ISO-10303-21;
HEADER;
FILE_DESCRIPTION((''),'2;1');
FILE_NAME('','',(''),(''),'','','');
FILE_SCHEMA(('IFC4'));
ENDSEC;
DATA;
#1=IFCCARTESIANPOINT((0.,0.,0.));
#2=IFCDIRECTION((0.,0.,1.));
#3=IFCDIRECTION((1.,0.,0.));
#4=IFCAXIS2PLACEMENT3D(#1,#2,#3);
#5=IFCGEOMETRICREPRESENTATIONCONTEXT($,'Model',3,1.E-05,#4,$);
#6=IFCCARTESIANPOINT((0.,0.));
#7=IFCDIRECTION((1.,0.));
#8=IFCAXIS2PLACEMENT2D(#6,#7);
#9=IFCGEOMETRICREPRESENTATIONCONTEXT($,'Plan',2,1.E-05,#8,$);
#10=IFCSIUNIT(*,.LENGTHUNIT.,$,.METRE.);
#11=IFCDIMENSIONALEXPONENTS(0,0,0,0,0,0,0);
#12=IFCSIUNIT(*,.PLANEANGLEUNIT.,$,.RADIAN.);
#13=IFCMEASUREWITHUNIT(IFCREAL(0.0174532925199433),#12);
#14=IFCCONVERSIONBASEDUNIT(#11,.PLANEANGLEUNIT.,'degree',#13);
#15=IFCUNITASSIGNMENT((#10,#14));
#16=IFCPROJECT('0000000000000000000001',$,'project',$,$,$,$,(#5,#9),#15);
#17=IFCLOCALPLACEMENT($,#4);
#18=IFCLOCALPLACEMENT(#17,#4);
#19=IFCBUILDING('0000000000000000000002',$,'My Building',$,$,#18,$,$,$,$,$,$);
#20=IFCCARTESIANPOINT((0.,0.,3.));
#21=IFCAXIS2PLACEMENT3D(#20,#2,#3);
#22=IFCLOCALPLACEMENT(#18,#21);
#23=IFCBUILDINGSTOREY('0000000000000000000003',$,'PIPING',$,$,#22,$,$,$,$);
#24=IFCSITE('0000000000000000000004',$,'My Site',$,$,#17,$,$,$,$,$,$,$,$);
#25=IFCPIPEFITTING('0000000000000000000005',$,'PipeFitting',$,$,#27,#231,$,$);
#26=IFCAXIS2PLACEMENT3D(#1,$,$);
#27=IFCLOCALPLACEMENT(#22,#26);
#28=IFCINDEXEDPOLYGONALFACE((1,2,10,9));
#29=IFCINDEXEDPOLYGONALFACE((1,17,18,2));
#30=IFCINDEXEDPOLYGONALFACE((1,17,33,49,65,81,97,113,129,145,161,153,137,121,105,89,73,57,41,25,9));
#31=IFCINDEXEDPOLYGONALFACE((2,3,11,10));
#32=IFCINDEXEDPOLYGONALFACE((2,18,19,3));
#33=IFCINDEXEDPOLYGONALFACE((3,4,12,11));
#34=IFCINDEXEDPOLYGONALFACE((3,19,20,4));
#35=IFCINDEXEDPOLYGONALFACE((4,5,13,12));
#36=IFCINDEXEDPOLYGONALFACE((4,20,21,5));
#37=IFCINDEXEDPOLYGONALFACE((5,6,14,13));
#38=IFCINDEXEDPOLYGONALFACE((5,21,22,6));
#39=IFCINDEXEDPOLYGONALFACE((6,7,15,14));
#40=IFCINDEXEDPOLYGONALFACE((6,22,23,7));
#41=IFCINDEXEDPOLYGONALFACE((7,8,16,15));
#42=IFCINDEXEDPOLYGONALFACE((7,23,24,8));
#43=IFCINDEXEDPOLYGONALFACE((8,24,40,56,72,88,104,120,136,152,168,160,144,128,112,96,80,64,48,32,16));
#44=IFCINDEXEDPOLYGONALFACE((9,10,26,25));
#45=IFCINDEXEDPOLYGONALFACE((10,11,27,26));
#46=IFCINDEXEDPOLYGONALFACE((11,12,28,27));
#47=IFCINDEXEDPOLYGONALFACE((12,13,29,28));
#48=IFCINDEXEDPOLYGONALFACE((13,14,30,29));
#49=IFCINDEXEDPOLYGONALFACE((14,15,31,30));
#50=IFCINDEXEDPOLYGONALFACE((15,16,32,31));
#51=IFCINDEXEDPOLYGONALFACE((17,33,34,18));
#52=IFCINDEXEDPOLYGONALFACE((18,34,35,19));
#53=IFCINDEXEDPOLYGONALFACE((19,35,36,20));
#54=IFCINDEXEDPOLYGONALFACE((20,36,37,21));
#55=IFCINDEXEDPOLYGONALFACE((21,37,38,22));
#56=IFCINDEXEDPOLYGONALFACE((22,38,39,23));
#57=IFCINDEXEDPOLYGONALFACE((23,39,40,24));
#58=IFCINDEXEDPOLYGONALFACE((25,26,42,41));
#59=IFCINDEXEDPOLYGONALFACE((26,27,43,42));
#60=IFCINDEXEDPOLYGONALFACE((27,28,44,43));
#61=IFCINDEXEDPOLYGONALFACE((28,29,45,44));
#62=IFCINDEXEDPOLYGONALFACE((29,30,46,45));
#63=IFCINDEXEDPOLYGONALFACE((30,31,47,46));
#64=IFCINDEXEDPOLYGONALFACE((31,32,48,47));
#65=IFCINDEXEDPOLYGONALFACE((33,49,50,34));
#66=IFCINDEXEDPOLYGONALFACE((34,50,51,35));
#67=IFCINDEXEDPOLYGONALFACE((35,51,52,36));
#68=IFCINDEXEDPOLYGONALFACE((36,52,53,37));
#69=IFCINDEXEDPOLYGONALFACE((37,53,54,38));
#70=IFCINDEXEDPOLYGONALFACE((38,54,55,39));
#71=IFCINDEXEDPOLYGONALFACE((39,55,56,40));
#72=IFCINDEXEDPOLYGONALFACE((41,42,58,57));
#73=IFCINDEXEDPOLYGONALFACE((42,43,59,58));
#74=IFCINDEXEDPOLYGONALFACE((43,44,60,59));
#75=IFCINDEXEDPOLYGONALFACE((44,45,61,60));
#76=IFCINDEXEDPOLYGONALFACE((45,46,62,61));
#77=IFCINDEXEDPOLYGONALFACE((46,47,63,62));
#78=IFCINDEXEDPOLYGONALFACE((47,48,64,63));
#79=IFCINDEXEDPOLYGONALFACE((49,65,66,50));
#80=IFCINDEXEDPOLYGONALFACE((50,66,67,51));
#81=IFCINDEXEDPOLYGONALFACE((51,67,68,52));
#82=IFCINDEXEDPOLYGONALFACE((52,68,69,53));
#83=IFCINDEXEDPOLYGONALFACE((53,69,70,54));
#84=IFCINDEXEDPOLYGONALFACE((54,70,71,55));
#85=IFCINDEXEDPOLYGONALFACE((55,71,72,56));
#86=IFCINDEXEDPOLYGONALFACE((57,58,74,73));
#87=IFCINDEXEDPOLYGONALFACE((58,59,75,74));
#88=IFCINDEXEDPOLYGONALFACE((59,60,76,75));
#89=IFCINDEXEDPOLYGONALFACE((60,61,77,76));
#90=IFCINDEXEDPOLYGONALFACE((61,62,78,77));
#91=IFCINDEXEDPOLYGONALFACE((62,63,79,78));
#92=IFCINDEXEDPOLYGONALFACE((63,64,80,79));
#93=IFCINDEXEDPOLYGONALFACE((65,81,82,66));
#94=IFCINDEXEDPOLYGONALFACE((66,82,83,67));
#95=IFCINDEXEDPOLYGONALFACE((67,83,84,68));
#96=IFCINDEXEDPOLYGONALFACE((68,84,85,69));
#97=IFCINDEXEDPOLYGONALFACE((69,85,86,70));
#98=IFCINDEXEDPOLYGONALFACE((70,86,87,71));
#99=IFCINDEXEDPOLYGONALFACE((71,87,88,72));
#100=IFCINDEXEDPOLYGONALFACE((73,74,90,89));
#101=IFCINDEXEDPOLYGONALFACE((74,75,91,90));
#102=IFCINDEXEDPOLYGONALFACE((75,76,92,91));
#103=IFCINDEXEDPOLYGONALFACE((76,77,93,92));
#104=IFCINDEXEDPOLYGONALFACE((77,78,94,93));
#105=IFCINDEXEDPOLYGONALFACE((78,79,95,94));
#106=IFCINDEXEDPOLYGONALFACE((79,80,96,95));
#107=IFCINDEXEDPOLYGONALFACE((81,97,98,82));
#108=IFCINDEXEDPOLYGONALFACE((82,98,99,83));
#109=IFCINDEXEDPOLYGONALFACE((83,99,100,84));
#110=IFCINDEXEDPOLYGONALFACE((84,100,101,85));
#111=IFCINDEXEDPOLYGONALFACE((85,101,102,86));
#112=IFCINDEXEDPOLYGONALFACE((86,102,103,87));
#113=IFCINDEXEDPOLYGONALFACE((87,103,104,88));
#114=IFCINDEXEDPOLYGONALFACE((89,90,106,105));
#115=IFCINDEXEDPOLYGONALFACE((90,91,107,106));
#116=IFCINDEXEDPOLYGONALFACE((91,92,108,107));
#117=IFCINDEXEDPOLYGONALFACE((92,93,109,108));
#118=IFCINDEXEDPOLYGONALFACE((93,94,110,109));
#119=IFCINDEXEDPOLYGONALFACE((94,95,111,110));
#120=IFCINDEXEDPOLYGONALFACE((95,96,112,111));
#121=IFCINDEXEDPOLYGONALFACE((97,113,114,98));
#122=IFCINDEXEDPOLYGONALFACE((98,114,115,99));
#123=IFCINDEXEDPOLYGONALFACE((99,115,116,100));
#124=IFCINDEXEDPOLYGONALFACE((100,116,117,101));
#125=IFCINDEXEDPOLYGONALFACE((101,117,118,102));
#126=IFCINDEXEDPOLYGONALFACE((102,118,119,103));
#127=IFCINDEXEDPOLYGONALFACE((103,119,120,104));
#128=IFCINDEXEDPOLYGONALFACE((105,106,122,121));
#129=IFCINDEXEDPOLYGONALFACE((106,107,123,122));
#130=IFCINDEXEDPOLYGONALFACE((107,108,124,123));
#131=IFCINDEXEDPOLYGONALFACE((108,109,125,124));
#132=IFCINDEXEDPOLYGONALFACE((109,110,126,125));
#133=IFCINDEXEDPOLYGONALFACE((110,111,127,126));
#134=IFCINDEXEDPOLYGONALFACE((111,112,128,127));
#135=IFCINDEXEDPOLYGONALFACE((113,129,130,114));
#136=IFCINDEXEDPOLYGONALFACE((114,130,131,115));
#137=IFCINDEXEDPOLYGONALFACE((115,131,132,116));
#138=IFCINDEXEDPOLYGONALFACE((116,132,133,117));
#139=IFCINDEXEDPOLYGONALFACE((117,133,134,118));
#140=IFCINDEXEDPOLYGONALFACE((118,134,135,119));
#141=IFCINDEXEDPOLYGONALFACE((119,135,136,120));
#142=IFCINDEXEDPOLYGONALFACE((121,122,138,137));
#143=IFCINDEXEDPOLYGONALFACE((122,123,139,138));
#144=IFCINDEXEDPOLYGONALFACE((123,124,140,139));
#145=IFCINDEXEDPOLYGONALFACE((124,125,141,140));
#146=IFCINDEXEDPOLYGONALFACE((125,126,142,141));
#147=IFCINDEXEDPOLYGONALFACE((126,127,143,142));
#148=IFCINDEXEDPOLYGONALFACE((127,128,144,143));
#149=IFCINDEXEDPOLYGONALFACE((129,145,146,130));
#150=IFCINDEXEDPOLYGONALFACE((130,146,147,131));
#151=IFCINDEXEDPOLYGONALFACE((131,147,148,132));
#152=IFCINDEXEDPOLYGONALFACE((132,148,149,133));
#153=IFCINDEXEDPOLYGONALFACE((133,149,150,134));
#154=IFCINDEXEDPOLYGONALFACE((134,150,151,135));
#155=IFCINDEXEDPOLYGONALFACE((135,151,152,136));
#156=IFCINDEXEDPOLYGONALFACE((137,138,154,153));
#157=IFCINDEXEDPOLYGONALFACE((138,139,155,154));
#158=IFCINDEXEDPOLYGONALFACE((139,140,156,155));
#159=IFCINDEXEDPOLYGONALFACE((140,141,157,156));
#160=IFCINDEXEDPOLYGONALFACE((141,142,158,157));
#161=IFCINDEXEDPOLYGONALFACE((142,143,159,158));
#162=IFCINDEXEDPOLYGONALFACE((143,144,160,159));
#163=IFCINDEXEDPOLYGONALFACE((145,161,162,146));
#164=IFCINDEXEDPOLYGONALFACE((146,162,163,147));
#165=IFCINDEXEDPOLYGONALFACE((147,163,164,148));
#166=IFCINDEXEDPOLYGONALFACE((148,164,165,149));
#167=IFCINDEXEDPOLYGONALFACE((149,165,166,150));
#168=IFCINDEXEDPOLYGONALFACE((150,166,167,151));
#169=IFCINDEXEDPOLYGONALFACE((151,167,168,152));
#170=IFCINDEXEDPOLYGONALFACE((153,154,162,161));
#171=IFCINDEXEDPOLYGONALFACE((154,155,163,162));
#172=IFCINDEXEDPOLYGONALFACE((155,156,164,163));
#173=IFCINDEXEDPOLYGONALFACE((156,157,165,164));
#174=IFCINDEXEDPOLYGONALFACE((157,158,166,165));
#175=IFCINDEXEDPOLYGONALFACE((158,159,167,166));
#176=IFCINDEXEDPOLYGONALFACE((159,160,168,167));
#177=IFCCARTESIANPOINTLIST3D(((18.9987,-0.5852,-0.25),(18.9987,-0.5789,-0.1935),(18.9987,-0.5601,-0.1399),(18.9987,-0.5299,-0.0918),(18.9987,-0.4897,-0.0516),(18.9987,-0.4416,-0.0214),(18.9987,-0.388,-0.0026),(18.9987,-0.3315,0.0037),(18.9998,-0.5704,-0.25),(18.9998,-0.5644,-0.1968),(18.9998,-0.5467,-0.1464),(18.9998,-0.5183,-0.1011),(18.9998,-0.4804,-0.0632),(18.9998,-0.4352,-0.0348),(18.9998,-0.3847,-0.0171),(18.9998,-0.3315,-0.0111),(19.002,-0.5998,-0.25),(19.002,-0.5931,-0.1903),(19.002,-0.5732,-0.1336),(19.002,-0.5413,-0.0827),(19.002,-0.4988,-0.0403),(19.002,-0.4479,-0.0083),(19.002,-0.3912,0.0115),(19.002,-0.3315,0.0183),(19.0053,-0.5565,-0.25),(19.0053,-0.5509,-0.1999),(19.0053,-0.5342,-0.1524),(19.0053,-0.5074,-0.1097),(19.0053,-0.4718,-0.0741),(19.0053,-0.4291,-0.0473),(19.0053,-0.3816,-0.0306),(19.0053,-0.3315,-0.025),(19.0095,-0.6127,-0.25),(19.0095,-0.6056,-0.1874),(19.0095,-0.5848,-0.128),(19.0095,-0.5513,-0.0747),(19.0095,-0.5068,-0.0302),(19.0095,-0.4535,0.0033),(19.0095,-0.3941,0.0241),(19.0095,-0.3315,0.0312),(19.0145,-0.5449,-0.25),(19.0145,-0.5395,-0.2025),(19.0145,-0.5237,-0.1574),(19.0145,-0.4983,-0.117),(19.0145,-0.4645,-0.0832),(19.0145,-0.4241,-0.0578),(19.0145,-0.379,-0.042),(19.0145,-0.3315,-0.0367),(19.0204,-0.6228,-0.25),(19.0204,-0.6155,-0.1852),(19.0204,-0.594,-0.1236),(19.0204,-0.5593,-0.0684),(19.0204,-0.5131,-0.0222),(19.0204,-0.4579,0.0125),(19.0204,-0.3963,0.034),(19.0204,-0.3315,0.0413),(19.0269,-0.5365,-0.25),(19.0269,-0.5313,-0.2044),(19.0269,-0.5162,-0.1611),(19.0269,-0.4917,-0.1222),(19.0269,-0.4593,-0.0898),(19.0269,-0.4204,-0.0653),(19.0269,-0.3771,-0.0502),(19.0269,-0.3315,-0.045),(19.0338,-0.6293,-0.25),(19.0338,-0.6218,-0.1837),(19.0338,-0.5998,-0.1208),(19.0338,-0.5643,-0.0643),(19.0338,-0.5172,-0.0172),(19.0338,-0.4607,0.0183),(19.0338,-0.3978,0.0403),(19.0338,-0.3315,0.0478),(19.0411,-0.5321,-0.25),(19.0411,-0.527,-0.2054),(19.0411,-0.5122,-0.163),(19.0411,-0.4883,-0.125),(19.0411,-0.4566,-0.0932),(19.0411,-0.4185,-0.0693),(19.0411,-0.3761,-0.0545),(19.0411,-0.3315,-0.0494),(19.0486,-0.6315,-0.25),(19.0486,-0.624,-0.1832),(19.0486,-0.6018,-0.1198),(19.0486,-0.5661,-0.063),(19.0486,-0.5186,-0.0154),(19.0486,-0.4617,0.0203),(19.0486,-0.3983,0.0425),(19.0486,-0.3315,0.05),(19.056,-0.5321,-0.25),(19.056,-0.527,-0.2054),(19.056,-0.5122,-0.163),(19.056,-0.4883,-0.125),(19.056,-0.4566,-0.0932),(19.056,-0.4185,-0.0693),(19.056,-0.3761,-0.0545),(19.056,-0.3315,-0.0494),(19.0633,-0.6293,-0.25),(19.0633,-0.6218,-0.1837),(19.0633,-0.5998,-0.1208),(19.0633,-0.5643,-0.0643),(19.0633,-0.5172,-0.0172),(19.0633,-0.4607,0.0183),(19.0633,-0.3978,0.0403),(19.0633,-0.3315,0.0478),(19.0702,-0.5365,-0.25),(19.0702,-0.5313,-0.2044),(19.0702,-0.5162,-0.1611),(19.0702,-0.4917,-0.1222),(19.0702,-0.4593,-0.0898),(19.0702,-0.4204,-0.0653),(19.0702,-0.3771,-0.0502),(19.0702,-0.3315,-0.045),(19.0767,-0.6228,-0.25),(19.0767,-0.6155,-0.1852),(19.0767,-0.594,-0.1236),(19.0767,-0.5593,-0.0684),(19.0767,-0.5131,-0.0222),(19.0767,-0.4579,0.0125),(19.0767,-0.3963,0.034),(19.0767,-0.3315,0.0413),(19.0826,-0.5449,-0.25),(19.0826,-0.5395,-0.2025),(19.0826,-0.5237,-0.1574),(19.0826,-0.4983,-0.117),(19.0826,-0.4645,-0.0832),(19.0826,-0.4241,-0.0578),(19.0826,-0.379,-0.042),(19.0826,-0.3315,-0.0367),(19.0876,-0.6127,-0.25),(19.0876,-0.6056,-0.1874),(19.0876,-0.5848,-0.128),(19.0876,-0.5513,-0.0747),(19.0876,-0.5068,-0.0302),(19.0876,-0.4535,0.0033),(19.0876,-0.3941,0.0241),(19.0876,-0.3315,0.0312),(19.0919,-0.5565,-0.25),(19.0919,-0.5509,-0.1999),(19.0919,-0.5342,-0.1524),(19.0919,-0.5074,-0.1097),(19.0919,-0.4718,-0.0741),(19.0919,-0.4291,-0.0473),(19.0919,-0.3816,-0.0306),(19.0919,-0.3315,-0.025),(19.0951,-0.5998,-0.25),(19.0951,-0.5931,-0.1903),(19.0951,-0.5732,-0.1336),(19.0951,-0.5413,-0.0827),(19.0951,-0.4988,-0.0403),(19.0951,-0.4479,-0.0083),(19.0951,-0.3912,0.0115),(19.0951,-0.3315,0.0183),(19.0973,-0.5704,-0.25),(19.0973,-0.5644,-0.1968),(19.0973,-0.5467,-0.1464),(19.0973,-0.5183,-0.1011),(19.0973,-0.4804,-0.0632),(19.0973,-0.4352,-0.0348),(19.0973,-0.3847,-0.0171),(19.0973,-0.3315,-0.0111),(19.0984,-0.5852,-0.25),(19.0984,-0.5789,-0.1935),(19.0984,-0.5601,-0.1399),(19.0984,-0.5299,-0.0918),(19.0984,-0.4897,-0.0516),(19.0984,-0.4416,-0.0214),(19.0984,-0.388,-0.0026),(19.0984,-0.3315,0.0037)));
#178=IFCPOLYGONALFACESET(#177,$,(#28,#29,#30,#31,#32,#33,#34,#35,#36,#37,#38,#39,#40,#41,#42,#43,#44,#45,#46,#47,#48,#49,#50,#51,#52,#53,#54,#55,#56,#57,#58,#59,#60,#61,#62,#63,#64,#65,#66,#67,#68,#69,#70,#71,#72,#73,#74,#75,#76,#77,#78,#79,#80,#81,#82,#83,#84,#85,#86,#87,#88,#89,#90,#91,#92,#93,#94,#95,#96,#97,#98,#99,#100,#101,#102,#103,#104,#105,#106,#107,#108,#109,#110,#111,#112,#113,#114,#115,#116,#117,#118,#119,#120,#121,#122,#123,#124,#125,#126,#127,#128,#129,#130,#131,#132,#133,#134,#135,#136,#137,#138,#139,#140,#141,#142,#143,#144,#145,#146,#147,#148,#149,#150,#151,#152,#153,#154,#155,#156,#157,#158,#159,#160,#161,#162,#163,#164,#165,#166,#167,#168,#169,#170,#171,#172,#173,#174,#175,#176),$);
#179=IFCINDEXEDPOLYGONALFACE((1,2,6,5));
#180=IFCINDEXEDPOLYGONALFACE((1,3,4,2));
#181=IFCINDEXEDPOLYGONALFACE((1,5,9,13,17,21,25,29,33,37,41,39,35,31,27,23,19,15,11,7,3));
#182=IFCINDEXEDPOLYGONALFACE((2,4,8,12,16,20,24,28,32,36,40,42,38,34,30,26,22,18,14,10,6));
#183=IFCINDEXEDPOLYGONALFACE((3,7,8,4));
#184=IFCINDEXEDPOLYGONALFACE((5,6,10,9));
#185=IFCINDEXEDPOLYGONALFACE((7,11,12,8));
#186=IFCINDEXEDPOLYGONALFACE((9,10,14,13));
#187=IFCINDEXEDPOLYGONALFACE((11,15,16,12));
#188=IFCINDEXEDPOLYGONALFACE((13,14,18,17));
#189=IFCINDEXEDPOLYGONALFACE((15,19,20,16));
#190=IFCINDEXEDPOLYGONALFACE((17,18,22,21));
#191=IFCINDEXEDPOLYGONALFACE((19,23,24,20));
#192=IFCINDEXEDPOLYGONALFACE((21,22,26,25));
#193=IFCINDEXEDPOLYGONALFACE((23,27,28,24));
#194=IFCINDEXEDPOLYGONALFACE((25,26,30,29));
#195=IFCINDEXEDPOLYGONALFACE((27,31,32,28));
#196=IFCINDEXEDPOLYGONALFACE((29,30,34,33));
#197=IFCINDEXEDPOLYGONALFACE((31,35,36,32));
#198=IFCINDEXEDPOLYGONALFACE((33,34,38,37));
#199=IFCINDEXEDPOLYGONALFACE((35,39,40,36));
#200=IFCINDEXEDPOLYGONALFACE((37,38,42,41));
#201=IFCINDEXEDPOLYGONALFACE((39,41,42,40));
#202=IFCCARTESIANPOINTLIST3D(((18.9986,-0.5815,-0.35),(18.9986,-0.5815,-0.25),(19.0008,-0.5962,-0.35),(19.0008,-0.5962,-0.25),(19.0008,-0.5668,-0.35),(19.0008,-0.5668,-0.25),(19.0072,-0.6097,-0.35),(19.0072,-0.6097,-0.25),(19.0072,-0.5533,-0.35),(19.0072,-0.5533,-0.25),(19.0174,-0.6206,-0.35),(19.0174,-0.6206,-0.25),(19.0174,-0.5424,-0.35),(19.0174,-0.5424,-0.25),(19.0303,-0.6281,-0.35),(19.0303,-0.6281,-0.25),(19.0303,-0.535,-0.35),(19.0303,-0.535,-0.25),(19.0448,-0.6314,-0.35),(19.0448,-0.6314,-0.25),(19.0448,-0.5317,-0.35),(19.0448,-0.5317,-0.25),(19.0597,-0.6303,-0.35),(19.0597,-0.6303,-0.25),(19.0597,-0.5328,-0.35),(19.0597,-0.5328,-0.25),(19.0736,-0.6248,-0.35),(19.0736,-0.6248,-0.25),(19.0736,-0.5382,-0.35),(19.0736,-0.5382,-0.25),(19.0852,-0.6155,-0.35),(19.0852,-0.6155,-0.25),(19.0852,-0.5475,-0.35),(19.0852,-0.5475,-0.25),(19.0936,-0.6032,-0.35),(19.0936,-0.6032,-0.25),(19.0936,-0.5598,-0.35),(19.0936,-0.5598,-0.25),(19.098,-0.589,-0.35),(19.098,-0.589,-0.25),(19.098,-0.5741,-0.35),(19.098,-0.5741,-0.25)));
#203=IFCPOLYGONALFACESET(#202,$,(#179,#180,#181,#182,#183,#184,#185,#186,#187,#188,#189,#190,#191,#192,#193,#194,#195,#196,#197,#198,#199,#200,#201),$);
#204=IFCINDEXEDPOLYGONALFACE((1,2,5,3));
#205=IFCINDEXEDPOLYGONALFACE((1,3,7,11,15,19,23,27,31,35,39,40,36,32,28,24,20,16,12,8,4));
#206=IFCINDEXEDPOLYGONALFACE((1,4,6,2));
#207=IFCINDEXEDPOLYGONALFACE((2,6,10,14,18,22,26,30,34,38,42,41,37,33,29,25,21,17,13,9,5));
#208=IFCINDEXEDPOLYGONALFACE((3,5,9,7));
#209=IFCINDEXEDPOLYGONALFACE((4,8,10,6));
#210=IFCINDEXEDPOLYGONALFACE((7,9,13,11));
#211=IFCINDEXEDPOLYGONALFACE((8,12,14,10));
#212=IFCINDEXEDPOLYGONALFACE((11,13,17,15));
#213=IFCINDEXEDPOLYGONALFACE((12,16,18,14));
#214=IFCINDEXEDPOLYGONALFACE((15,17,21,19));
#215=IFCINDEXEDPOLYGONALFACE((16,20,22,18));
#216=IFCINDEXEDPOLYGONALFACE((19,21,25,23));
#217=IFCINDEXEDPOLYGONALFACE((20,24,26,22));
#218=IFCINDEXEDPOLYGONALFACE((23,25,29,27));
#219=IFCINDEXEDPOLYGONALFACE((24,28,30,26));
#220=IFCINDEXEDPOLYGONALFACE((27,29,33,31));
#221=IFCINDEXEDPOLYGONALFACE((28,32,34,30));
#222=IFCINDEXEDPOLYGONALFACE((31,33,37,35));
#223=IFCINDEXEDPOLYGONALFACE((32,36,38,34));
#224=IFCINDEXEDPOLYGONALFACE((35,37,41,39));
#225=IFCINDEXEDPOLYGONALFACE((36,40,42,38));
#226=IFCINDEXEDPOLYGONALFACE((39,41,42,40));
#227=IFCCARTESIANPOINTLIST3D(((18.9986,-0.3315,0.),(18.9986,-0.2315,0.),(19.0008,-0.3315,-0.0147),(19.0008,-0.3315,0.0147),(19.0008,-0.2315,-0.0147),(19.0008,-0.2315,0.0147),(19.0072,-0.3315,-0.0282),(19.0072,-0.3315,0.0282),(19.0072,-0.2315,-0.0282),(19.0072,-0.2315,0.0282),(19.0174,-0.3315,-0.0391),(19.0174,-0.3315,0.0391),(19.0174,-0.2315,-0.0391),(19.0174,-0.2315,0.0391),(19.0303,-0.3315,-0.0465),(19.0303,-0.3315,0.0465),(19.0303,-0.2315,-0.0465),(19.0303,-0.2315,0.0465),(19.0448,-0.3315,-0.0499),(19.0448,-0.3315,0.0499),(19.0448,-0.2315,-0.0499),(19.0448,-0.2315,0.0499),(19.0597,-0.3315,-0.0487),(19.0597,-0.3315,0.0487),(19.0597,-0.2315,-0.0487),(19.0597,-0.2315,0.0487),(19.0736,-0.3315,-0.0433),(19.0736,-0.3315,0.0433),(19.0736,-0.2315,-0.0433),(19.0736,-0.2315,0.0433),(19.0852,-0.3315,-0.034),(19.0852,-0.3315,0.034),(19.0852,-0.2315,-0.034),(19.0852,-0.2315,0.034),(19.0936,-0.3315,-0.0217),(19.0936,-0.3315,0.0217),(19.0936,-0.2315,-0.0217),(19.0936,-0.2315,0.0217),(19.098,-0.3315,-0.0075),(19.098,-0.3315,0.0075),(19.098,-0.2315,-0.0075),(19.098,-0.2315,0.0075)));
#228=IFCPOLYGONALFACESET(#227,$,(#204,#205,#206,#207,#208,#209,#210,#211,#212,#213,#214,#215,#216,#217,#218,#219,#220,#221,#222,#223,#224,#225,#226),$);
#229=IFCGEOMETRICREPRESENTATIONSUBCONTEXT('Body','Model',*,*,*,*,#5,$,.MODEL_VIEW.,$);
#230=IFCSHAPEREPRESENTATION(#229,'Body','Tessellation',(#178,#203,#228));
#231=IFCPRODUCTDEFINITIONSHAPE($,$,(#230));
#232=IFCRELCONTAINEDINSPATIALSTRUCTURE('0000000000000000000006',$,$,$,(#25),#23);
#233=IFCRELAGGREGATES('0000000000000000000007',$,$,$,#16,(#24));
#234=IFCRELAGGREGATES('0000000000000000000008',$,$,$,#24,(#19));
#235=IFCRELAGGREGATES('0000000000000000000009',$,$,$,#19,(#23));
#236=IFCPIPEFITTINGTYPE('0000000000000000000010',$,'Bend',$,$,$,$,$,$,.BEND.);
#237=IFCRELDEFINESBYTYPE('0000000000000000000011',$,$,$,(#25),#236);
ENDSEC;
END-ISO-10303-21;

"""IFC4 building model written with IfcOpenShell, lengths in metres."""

from ifc_helpers import new_model, entity, si_unit, converted_unit, frame, origin_with_axes, origin_2d_with_axis, place, context, subcontext, project, spatial, circle, extrude, source, transform, mapped, type_object, type_shapes, element, save


model = new_model("IFC4")

# Units and contexts
model_context = context("Model", 3, precision=1e-05, world=origin_with_axes())
plan_context = context("Plan", 2, precision=1e-05, world=origin_2d_with_axis())
body_context = subcontext(model_context, "Body", "Model", "MODEL_VIEW")
ifc_project = project(units=[si_unit("LENGTHUNIT", "METRE"), converted_unit("PLANEANGLEUNIT", "degree", entity("IfcReal", 0.0174532925199433), si_unit("PLANEANGLEUNIT", "RADIAN"), dimensions=[0, 0, 0, 0, 0, 0, 0])], contexts=[model_context, plan_context])

# Site, building, storey
site_placement = place(None, origin_with_axes())
site = spatial("IfcSite", under=ifc_project, at=site_placement, Name="My Site")
building_placement = place(site_placement, origin_with_axes())
building = spatial("IfcBuilding", under=site, at=building_placement, Name="My Building")
storey_placement = place(building_placement, frame((0.0, 0.0, 3.0), z_axis=(0.0, 0.0, 1.0), x_axis=(1.0, 0.0, 0.0)))
storey = spatial("IfcBuildingStorey", under=building, at=storey_placement, Name="PIPING")

# Pipe fitting
pipe_fitting_type = type_object("IfcPipeFittingType", Name="Bend", PredefinedType="BEND")
shared_shape = source(origin_with_axes(), body_context, "Body", "SolidModel", [
    entity("IfcSweptDiskSolid", entity("IfcIndexedPolyCurve", entity("IfcCartesianPointList3D", [[0.0, 0.0, 0.1], [0.0, -0.0732, 0.2768], [0.0, -0.25, 0.35]]), [entity("IfcArcIndex", [1, 2, 3])]), 0.05),
    extrude(circle(Radius=0.05), origin_with_axes(), (0.0, 0.0, 1.0), 0.1),
    extrude(circle(Radius=0.05), frame((0.0, -0.25, 0.35), z_axis=(0.0, -1.0, 0.0), x_axis=(1.0, 0.0, 0.0)), (0.0, 0.0, 1.0), 0.1),
])
type_shapes(pipe_fitting_type, [shared_shape])
for number, where, z_axis, x_axis, name in (
    (1, (19.0486, -0.5815, -0.35), (0.0, 0.0, 1.0), (-1.0, 0.0, 0.0), "PipeFitting"),
):
    element("IfcPipeFitting", number, at=place(storey_placement, frame(where, z_axis=z_axis, x_axis=x_axis)), inside=storey, type_object=pipe_fitting_type, Name=name, context=body_context, shape_type="MappedRepresentation", body=[
        mapped(shared_shape, transform((0.0, 0.0, 0.0), x_axis=(1.0, 0.0, 0.0), y_axis=(0.0, 1.0, 0.0), z_axis=(0.0, 0.0, 1.0), scale=1.0)),
    ])

save(model, "model.ifc")
